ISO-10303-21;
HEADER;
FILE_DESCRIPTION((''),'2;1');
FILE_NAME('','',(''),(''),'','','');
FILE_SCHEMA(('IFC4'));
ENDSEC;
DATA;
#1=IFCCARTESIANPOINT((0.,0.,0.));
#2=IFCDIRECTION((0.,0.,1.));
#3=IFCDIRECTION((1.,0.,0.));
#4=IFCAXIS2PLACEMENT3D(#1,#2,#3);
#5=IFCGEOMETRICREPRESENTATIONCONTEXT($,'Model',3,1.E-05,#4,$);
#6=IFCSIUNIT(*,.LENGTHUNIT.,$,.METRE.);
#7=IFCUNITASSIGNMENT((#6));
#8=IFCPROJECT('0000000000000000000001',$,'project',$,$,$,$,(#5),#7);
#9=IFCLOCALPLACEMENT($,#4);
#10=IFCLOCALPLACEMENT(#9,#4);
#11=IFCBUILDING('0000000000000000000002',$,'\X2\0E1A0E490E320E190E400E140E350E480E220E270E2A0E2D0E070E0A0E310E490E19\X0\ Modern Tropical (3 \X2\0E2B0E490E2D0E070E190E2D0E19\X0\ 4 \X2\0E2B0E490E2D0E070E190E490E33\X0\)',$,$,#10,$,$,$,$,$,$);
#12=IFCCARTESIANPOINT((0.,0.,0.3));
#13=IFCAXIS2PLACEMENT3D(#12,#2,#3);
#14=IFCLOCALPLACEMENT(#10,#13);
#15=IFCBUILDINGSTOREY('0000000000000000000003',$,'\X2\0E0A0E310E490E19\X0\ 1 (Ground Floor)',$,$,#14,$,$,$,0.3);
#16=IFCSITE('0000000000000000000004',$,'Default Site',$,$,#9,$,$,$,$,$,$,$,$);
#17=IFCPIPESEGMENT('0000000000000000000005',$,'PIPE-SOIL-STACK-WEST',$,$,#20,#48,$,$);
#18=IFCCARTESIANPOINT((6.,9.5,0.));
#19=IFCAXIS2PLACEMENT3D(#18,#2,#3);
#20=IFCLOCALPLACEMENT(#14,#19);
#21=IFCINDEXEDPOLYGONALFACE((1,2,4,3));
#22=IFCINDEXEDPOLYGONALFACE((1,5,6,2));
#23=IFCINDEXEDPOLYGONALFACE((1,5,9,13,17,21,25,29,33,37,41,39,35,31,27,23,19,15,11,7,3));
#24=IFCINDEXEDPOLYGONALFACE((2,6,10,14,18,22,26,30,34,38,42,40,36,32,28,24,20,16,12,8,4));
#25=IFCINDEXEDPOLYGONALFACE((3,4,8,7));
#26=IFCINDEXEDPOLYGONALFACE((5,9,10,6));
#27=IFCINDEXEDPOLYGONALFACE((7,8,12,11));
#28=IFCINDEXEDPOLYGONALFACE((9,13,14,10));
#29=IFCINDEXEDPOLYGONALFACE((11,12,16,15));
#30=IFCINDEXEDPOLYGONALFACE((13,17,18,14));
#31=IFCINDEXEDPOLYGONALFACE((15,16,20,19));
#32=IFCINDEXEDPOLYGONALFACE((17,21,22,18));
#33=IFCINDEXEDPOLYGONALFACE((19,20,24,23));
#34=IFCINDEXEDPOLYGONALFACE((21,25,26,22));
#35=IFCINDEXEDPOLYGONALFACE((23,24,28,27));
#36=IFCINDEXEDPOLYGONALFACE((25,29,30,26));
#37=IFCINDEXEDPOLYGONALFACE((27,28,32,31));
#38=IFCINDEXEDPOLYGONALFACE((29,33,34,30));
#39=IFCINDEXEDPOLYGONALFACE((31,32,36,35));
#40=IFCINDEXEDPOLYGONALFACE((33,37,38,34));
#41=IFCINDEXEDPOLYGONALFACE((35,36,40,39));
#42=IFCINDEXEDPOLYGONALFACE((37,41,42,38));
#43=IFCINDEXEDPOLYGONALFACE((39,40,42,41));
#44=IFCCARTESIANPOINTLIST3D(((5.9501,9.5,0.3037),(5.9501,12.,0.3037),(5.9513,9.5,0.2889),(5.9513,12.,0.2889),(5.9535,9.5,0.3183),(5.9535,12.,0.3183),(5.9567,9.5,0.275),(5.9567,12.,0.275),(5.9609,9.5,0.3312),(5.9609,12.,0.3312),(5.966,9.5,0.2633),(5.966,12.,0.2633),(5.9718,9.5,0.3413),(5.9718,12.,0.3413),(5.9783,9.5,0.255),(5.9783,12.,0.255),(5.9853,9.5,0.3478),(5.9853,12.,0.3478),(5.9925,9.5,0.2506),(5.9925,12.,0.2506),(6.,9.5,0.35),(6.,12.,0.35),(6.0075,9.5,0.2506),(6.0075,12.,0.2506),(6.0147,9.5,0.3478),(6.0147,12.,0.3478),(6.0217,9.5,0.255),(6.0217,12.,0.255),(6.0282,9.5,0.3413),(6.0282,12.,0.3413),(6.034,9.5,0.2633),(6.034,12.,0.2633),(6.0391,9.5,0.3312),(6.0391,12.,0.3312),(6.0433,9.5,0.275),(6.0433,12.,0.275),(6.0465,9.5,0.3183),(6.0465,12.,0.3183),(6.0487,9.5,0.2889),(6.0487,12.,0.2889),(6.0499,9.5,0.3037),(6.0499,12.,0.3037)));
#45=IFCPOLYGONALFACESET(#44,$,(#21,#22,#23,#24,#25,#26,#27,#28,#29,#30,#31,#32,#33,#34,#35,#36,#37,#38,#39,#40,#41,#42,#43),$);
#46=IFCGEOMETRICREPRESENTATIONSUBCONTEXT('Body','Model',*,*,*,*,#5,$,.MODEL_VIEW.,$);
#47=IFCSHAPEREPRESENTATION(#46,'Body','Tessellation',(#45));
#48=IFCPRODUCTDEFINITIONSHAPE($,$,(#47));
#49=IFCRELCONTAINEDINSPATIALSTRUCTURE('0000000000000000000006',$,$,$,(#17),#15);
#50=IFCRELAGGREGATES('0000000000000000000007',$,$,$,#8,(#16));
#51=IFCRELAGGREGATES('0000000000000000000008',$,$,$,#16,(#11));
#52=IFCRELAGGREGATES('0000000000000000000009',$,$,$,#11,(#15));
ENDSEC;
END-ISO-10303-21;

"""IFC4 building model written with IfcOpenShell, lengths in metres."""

from ifc_helpers import new_model, entity, si_unit, frame, origin_with_axes, place, context, subcontext, project, spatial, element, save


model = new_model("IFC4")

# Units and contexts
model_context = context("Model", 3, precision=1e-05, world=origin_with_axes())
body_context = subcontext(model_context, "Body", "Model", "MODEL_VIEW")
ifc_project = project(units=[si_unit("LENGTHUNIT", "METRE")], contexts=[model_context])

# Site, building, storey
site_placement = place(None, origin_with_axes())
site = spatial("IfcSite", under=ifc_project, at=site_placement, Name="Default Site")
building_placement = place(site_placement, origin_with_axes())
building = spatial("IfcBuilding", under=site, at=building_placement, Name="บ้านเดี่ยวสองชั้น Modern Tropical (3 ห้องนอน 4 ห้องน้ำ)")
storey_placement = place(building_placement, frame((0.0, 0.0, 0.3), z_axis=(0.0, 0.0, 1.0), x_axis=(1.0, 0.0, 0.0)))
storey = spatial("IfcBuildingStorey", under=building, at=storey_placement, Name="ชั้น 1 (Ground Floor)", Elevation=0.3)

# Pipe segment
pipe_segment_placement = place(storey_placement, frame((6.0, 9.5, 0.0), z_axis=(0.0, 0.0, 1.0), x_axis=(1.0, 0.0, 0.0)))
element("IfcPipeSegment", 1, at=pipe_segment_placement, inside=storey, Name="PIPE-SOIL-STACK-WEST", context=body_context, shape_type="SweptSolid", body=[
    entity("IfcSweptDiskSolid", entity("IfcPolyline", [entity("IfcCartesianPoint", [6.0, 9.5, 0.3]), entity("IfcCartesianPoint", [6.0, 12.0, 0.3])]), 0.05),
])

save(model, "model.ifc")
